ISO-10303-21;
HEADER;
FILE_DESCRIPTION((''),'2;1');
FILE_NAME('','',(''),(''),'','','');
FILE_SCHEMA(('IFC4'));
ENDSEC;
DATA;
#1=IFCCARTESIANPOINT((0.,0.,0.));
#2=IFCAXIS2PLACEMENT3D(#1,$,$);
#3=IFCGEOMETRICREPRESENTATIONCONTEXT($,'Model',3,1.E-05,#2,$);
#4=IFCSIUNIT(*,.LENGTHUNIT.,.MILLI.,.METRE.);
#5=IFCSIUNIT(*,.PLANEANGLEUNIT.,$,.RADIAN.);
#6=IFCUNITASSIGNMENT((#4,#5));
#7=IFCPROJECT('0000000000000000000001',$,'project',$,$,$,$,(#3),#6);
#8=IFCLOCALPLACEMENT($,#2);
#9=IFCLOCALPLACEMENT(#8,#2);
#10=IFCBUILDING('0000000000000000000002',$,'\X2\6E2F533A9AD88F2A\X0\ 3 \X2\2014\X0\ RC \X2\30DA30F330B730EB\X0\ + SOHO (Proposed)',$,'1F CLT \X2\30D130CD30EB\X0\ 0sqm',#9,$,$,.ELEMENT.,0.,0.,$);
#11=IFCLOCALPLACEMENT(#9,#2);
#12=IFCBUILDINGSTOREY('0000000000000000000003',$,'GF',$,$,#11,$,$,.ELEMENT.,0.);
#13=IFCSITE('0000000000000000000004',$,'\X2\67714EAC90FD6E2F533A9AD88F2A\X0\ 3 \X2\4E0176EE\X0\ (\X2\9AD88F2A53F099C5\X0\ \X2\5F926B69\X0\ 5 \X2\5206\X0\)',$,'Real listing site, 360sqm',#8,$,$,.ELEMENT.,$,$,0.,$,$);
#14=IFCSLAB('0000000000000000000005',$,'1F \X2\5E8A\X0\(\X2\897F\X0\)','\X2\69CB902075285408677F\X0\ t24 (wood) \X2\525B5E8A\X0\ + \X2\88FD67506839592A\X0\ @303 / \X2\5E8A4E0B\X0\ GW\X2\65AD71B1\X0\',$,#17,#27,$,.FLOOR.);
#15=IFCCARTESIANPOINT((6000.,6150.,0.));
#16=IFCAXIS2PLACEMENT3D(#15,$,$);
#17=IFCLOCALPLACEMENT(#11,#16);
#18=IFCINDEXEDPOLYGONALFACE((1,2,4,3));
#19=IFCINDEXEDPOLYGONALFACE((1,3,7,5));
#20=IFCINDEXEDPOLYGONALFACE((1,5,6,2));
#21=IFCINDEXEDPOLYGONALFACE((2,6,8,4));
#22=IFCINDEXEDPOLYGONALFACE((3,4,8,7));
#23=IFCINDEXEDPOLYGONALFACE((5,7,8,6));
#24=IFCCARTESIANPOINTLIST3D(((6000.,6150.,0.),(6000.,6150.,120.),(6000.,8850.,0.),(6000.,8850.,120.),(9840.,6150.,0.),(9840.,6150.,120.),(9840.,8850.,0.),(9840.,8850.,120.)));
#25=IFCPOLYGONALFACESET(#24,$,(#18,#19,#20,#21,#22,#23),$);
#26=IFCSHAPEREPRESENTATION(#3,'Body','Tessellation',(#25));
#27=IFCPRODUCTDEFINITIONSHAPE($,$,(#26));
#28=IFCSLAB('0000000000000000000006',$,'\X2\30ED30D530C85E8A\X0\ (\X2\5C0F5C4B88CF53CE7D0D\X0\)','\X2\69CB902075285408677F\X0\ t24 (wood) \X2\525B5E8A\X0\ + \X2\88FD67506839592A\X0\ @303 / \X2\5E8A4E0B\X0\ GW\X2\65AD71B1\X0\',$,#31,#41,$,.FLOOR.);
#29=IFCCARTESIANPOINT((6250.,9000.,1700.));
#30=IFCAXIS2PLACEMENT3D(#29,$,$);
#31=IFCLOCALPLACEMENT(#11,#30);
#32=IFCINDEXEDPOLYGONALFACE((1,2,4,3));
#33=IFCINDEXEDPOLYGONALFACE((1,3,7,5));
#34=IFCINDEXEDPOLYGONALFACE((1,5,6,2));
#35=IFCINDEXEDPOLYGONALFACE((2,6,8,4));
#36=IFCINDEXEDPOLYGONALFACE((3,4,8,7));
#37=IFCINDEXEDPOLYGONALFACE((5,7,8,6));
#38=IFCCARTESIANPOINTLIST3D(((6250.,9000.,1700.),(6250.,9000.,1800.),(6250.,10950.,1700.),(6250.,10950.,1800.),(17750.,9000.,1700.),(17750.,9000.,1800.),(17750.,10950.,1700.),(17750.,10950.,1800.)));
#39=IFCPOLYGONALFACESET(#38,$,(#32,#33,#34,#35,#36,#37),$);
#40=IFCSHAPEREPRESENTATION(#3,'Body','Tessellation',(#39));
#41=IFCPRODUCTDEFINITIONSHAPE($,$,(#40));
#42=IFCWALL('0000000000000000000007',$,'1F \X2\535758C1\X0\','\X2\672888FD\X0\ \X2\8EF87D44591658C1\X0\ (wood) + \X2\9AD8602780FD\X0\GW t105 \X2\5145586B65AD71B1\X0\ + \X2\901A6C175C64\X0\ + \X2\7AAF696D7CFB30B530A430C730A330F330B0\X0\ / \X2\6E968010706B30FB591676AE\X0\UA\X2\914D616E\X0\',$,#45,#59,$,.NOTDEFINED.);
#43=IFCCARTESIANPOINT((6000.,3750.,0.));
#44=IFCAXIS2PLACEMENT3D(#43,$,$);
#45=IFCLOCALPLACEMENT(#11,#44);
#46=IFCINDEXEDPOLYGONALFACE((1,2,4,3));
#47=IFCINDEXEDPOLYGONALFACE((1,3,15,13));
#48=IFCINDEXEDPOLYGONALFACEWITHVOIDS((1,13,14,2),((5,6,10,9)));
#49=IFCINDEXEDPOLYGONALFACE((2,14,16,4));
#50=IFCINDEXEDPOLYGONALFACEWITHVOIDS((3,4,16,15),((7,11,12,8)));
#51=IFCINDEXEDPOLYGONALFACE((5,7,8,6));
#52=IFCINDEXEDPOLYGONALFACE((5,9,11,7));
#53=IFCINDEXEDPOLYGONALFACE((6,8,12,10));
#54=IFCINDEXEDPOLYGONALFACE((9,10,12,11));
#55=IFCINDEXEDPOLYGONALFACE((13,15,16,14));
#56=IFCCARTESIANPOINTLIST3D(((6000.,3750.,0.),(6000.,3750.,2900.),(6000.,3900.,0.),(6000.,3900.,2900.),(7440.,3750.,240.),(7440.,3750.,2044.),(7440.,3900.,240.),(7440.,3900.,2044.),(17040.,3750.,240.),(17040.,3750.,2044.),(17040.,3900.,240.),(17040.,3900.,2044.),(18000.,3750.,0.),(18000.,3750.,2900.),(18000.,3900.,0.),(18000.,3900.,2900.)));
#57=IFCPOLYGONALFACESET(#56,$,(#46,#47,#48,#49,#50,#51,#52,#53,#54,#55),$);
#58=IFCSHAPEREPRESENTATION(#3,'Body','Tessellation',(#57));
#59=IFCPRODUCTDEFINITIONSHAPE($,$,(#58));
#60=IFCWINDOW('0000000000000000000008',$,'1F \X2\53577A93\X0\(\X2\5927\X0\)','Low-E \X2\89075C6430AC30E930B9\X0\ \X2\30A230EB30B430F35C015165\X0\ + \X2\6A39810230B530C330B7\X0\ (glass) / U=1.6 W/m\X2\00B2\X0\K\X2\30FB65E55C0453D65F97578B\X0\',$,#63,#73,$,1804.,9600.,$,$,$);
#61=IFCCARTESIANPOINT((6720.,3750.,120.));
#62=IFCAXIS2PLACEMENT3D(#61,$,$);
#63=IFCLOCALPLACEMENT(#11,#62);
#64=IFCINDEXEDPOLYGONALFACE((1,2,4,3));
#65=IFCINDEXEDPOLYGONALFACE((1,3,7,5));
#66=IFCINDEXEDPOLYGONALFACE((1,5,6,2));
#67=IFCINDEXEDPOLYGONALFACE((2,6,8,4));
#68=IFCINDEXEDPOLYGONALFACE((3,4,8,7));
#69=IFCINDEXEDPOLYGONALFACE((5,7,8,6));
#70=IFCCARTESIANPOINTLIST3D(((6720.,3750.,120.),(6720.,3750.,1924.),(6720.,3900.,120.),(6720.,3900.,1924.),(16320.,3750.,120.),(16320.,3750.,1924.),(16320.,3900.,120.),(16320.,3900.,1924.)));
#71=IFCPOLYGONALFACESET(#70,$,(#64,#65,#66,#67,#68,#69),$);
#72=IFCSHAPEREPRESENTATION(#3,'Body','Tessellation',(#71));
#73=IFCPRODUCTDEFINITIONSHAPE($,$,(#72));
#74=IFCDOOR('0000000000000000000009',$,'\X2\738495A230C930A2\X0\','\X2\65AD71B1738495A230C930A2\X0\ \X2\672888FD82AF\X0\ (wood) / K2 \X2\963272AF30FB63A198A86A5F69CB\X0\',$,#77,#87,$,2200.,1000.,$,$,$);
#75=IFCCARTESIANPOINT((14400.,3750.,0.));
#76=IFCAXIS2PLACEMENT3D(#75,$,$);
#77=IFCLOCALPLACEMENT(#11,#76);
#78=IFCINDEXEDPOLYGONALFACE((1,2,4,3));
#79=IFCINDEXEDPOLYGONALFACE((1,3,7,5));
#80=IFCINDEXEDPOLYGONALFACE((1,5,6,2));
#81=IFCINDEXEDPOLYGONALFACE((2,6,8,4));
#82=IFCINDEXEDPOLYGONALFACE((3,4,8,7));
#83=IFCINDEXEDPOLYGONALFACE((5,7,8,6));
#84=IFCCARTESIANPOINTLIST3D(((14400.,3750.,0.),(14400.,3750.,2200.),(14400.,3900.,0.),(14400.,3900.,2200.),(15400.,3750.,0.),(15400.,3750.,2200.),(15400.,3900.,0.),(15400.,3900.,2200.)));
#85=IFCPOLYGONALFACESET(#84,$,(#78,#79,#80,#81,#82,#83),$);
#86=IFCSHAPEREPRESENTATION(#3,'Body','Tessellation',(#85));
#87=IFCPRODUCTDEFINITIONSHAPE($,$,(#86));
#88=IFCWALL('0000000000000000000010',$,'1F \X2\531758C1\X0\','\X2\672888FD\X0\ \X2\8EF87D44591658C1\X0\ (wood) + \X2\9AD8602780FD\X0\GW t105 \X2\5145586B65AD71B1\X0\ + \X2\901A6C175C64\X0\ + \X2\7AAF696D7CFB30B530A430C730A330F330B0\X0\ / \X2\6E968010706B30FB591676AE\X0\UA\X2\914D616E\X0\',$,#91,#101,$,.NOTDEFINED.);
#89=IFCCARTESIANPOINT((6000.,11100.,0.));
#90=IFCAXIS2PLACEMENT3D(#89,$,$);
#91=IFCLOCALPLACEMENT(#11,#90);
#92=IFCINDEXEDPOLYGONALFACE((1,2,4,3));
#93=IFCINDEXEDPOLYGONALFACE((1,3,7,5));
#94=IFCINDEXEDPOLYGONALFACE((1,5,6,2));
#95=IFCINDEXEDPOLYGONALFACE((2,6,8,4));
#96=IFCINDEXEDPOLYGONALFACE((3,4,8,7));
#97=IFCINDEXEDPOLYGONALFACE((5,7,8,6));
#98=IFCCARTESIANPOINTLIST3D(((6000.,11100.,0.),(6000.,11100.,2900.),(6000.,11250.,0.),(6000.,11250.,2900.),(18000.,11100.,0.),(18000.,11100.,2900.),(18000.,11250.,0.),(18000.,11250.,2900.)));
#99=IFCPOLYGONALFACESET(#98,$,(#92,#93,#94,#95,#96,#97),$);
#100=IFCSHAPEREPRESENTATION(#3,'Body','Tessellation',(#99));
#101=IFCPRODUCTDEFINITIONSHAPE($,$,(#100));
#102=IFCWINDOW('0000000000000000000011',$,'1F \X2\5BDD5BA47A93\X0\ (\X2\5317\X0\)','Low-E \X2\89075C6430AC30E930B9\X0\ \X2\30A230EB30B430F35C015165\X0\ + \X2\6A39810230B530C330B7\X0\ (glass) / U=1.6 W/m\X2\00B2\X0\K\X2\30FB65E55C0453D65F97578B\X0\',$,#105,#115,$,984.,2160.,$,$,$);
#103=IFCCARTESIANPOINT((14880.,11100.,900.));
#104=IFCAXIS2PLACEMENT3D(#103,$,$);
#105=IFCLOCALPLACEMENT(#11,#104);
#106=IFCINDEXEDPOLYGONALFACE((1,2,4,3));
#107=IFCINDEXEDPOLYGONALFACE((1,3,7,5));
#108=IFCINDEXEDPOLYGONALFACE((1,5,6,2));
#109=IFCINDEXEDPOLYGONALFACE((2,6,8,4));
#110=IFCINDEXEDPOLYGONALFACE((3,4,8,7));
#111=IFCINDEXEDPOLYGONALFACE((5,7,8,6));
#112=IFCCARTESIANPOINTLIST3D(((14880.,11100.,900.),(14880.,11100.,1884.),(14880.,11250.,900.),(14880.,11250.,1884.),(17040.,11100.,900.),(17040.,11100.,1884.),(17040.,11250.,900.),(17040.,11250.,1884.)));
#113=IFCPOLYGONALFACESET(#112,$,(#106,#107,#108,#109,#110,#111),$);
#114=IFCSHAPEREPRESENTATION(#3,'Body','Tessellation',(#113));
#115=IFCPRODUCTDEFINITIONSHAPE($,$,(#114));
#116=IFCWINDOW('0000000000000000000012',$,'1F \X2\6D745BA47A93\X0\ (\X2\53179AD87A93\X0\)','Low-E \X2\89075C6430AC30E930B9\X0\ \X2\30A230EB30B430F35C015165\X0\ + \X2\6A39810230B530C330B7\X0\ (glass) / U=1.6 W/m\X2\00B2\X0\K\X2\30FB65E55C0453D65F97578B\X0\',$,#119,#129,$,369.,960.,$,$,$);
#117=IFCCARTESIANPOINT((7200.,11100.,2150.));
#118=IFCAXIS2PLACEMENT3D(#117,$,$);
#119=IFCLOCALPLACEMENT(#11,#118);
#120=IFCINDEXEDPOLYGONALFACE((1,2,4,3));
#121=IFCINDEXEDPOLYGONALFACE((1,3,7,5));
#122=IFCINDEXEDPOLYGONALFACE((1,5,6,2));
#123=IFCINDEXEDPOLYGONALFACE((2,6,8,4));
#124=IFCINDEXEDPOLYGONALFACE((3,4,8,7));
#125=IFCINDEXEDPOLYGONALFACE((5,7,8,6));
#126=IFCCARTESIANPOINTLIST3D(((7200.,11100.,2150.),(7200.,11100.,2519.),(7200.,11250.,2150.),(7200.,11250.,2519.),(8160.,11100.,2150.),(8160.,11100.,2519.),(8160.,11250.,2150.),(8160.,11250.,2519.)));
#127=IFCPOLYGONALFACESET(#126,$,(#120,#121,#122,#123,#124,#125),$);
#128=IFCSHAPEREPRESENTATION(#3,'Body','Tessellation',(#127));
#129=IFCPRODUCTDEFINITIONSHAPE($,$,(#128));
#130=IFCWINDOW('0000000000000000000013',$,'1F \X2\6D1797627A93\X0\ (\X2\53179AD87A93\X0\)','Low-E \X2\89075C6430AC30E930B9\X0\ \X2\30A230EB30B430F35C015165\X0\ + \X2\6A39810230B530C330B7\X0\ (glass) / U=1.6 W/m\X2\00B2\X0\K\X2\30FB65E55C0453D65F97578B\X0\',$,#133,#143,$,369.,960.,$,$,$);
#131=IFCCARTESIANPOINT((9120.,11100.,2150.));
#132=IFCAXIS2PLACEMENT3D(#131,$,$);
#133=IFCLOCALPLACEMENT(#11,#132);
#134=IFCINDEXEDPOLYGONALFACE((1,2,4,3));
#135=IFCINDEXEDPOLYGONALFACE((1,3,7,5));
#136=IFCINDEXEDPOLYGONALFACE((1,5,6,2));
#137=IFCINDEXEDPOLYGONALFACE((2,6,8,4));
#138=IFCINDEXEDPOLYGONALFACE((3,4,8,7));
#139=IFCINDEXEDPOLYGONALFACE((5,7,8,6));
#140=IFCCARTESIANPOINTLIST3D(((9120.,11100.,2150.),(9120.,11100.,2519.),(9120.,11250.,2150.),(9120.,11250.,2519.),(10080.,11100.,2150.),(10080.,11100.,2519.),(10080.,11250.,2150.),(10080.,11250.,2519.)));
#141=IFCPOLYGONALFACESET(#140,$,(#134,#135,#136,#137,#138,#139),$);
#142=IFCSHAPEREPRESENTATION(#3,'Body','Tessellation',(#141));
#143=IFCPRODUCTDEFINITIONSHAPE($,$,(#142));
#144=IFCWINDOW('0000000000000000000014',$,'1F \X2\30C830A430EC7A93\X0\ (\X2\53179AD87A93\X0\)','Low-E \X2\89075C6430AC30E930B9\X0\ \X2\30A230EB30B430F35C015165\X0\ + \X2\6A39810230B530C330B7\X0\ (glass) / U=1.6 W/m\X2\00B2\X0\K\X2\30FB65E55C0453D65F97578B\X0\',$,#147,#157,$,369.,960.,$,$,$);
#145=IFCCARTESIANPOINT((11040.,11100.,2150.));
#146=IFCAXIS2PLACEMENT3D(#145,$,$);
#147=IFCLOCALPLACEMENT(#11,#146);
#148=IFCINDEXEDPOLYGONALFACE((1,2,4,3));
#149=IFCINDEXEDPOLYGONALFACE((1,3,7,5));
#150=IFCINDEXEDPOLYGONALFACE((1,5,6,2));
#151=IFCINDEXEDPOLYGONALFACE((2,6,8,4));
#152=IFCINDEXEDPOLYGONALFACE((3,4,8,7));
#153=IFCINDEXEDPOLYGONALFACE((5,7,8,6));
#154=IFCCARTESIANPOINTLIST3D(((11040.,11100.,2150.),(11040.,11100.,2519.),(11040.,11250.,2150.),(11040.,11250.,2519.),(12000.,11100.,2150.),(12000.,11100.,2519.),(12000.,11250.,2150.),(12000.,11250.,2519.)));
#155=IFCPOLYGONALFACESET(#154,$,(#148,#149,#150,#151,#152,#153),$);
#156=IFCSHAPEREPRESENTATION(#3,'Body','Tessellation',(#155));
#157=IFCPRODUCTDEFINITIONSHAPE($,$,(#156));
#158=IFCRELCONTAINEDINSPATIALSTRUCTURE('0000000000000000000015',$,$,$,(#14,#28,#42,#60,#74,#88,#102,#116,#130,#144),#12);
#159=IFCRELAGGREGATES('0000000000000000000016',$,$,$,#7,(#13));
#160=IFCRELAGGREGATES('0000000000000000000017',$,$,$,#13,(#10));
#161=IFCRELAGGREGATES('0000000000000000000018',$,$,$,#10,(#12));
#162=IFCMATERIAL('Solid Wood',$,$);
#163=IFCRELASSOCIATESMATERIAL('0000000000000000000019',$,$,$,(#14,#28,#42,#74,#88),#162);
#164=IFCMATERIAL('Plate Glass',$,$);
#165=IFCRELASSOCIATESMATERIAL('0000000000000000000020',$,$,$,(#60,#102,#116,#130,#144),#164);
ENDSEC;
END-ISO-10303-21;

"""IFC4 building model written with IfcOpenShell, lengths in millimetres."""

from ifc_helpers import new_model, si_unit, frame, frame_2d, origin, place, context, project, spatial, rectangle, extrude, material, element, fill, save


model = new_model("IFC4")

# Units and contexts
model_context = context("Model", 3, precision=1e-05, world=origin())
ifc_project = project(units=[si_unit("LENGTHUNIT", "METRE", prefix="MILLI"), si_unit("PLANEANGLEUNIT", "RADIAN")], contexts=[model_context])

# Site, building, storey
site_placement = place(None, origin())
site = spatial("IfcSite", under=ifc_project, at=site_placement, Name="東京都港区高輪 3 丁目 (高輪台駅 徒歩 5 分)", ObjectType="Real listing site, 360sqm", CompositionType="ELEMENT", RefElevation=0.0)
building_placement = place(site_placement, origin())
building = spatial("IfcBuilding", under=site, at=building_placement, Name="港区高輪 3 — RC ペンシル + SOHO (Proposed)", ObjectType="1F CLT パネル 0sqm", CompositionType="ELEMENT", ElevationOfRefHeight=0.0, ElevationOfTerrain=0.0)
storey_placement = place(building_placement, origin())
storey = spatial("IfcBuildingStorey", under=building, at=storey_placement, Name="GF", CompositionType="ELEMENT", Elevation=0.0)

# Slabs
ifc_material_1 = material(Name="Solid Wood")
slab_1_placement = place(storey_placement, frame((6000.0, 6150.0, 0.0)))
element("IfcSlab", 1, at=slab_1_placement, inside=storey, material=ifc_material_1, Name="1F 床(西)", Description="構造用合板 t24 (wood) 剛床 + 製材根太 @303 / 床下 GW断熱", PredefinedType="FLOOR", context=model_context, shape_type="SweptSolid", body=[
    extrude(rectangle(XDim=3840.0, YDim=2700.0, at=frame_2d((1920.0, 1350.0))), frame((6000.0, 6150.0, 0.0)), (0.0, 0.0, 1.0), 120.0),
])
slab_2_placement = place(storey_placement, frame((6250.0, 9000.0, 1700.0)))
element("IfcSlab", 2, at=slab_2_placement, inside=storey, material=ifc_material_1, Name="ロフト床 (小屋裏収納)", Description="構造用合板 t24 (wood) 剛床 + 製材根太 @303 / 床下 GW断熱", PredefinedType="FLOOR", context=model_context, shape_type="SweptSolid", body=[
    extrude(rectangle(XDim=11500.0, YDim=1950.0, at=frame_2d((5750.0, 975.0))), frame((6250.0, 9000.0, 1700.0)), (0.0, 0.0, 1.0), 100.0),
])

# Wall, openings, window, door
wall_1_placement = place(storey_placement, frame((6000.0, 3750.0, 0.0)))
wall_1 = element("IfcWall", 3, at=wall_1_placement, inside=storey, material=ifc_material_1, Name="1F 南壁", Description="木製 軸組外壁 (wood) + 高性能GW t105 充填断熱 + 通気層 + 窯業系サイディング / 準耐火・外皮UA配慮", PredefinedType="NOTDEFINED", context=model_context, shape_type="SweptSolid", body=[
    extrude(rectangle(XDim=12000.0, YDim=150.0, at=frame_2d((6000.0, 75.0))), frame((6000.0, 3750.0, 0.0)), (0.0, 0.0, 1.0), 2900.0),
])
opening_1_placement = place(storey_placement, frame((6720.0, 3750.0, 120.0)))
opening_1 = element("IfcOpeningElement", 4, at=opening_1_placement, cuts=wall_1, PredefinedType="NOTDEFINED", context=model_context, shape_type="SweptSolid", body=[
    extrude(rectangle(XDim=9600.0, YDim=150.0, at=frame_2d((4800.0, 75.0))), frame((6720.0, 3750.0, 120.0)), (0.0, 0.0, 1.0), 1804.0),
])
opening_2_placement = place(storey_placement, frame((14400.0, 3750.0, 0.0)))
opening_2 = element("IfcOpeningElement", 5, at=opening_2_placement, cuts=wall_1, PredefinedType="NOTDEFINED", context=model_context, shape_type="SweptSolid", body=[
    extrude(rectangle(XDim=1000.0, YDim=150.0, at=frame_2d((500.0, 75.0))), frame((14400.0, 3750.0, 0.0)), (0.0, 0.0, 1.0), 2200.0),
])
ifc_material_2 = material(Name="Plate Glass")
window_1_placement = place(storey_placement, frame((6720.0, 3750.0, 120.0)))
window_1 = element("IfcWindow", 6, at=window_1_placement, inside=storey, material=ifc_material_2, Name="1F 南窓(大)", Description="Low-E 複層ガラス アルゴン封入 + 樹脂サッシ (glass) / U=1.6 W/m²K・日射取得型", OverallHeight=1804.0, OverallWidth=9600.0, context=model_context, shape_type="SweptSolid", body=[
    extrude(rectangle(XDim=9600.0, YDim=150.0, at=frame_2d((4800.0, 75.0))), frame((6720.0, 3750.0, 120.0)), (0.0, 0.0, 1.0), 1804.0),
])
fill(opening_1, window_1)
door_1_placement = place(storey_placement, frame((14400.0, 3750.0, 0.0)))
door_1 = element("IfcDoor", 7, at=door_1_placement, inside=storey, material=ifc_material_1, Name="玄関ドア", Description="断熱玄関ドア 木製芯 (wood) / K2 防犯・採風機構", OverallHeight=2200.0, OverallWidth=1000.0, context=model_context, shape_type="SweptSolid", body=[
    extrude(rectangle(XDim=1000.0, YDim=150.0, at=frame_2d((500.0, 75.0))), frame((14400.0, 3750.0, 0.0)), (0.0, 0.0, 1.0), 2200.0),
])
fill(opening_2, door_1)

# Wall, openings, windows
wall_2_placement = place(storey_placement, frame((6000.0, 11100.0, 0.0)))
wall_2 = element("IfcWall", 8, at=wall_2_placement, inside=storey, material=ifc_material_1, Name="1F 北壁", Description="木製 軸組外壁 (wood) + 高性能GW t105 充填断熱 + 通気層 + 窯業系サイディング / 準耐火・外皮UA配慮", PredefinedType="NOTDEFINED", context=model_context, shape_type="SweptSolid", body=[
    extrude(rectangle(XDim=12000.0, YDim=150.0, at=frame_2d((6000.0, 75.0))), frame((6000.0, 11100.0, 0.0)), (0.0, 0.0, 1.0), 2900.0),
])
opening_3_placement = place(storey_placement, frame((14880.0, 11100.0, 900.0)))
opening_3 = element("IfcOpeningElement", 9, at=opening_3_placement, cuts=wall_2, PredefinedType="NOTDEFINED", context=model_context, shape_type="SweptSolid", body=[
    extrude(rectangle(XDim=2160.0, YDim=150.0, at=frame_2d((1080.0, 75.0))), frame((14880.0, 11100.0, 900.0)), (0.0, 0.0, 1.0), 984.0),
])
opening_4_placement = place(storey_placement, frame((7200.0, 11100.0, 2150.0)))
opening_4 = element("IfcOpeningElement", 10, at=opening_4_placement, cuts=wall_2, PredefinedType="NOTDEFINED", context=model_context, shape_type="SweptSolid", body=[
    extrude(rectangle(XDim=960.0, YDim=150.0, at=frame_2d((480.0, 75.0))), frame((7200.0, 11100.0, 2150.0)), (0.0, 0.0, 1.0), 369.0),
])
opening_5_placement = place(storey_placement, frame((9120.0, 11100.0, 2150.0)))
opening_5 = element("IfcOpeningElement", 11, at=opening_5_placement, cuts=wall_2, PredefinedType="NOTDEFINED", context=model_context, shape_type="SweptSolid", body=[
    extrude(rectangle(XDim=960.0, YDim=150.0, at=frame_2d((480.0, 75.0))), frame((9120.0, 11100.0, 2150.0)), (0.0, 0.0, 1.0), 369.0),
])
opening_6_placement = place(storey_placement, frame((11040.0, 11100.0, 2150.0)))
opening_6 = element("IfcOpeningElement", 12, at=opening_6_placement, cuts=wall_2, PredefinedType="NOTDEFINED", context=model_context, shape_type="SweptSolid", body=[
    extrude(rectangle(XDim=960.0, YDim=150.0, at=frame_2d((480.0, 75.0))), frame((11040.0, 11100.0, 2150.0)), (0.0, 0.0, 1.0), 369.0),
])
window_2_placement = place(storey_placement, frame((14880.0, 11100.0, 900.0)))
window_2 = element("IfcWindow", 13, at=window_2_placement, inside=storey, material=ifc_material_2, Name="1F 寝室窓 (北)", Description="Low-E 複層ガラス アルゴン封入 + 樹脂サッシ (glass) / U=1.6 W/m²K・日射取得型", OverallHeight=984.0, OverallWidth=2160.0, context=model_context, shape_type="SweptSolid", body=[
    extrude(rectangle(XDim=2160.0, YDim=150.0, at=frame_2d((1080.0, 75.0))), frame((14880.0, 11100.0, 900.0)), (0.0, 0.0, 1.0), 984.0),
])
fill(opening_3, window_2)
window_3_placement = place(storey_placement, frame((7200.0, 11100.0, 2150.0)))
window_3 = element("IfcWindow", 14, at=window_3_placement, inside=storey, material=ifc_material_2, Name="1F 浴室窓 (北高窓)", Description="Low-E 複層ガラス アルゴン封入 + 樹脂サッシ (glass) / U=1.6 W/m²K・日射取得型", OverallHeight=369.0, OverallWidth=960.0, context=model_context, shape_type="SweptSolid", body=[
    extrude(rectangle(XDim=960.0, YDim=150.0, at=frame_2d((480.0, 75.0))), frame((7200.0, 11100.0, 2150.0)), (0.0, 0.0, 1.0), 369.0),
])
fill(opening_4, window_3)
window_4_placement = place(storey_placement, frame((9120.0, 11100.0, 2150.0)))
window_4 = element("IfcWindow", 15, at=window_4_placement, inside=storey, material=ifc_material_2, Name="1F 洗面窓 (北高窓)", Description="Low-E 複層ガラス アルゴン封入 + 樹脂サッシ (glass) / U=1.6 W/m²K・日射取得型", OverallHeight=369.0, OverallWidth=960.0, context=model_context, shape_type="SweptSolid", body=[
    extrude(rectangle(XDim=960.0, YDim=150.0, at=frame_2d((480.0, 75.0))), frame((9120.0, 11100.0, 2150.0)), (0.0, 0.0, 1.0), 369.0),
])
fill(opening_5, window_4)
window_5_placement = place(storey_placement, frame((11040.0, 11100.0, 2150.0)))
window_5 = element("IfcWindow", 16, at=window_5_placement, inside=storey, material=ifc_material_2, Name="1F トイレ窓 (北高窓)", Description="Low-E 複層ガラス アルゴン封入 + 樹脂サッシ (glass) / U=1.6 W/m²K・日射取得型", OverallHeight=369.0, OverallWidth=960.0, context=model_context, shape_type="SweptSolid", body=[
    extrude(rectangle(XDim=960.0, YDim=150.0, at=frame_2d((480.0, 75.0))), frame((11040.0, 11100.0, 2150.0)), (0.0, 0.0, 1.0), 369.0),
])
fill(opening_6, window_5)

save(model, "model.ifc")
